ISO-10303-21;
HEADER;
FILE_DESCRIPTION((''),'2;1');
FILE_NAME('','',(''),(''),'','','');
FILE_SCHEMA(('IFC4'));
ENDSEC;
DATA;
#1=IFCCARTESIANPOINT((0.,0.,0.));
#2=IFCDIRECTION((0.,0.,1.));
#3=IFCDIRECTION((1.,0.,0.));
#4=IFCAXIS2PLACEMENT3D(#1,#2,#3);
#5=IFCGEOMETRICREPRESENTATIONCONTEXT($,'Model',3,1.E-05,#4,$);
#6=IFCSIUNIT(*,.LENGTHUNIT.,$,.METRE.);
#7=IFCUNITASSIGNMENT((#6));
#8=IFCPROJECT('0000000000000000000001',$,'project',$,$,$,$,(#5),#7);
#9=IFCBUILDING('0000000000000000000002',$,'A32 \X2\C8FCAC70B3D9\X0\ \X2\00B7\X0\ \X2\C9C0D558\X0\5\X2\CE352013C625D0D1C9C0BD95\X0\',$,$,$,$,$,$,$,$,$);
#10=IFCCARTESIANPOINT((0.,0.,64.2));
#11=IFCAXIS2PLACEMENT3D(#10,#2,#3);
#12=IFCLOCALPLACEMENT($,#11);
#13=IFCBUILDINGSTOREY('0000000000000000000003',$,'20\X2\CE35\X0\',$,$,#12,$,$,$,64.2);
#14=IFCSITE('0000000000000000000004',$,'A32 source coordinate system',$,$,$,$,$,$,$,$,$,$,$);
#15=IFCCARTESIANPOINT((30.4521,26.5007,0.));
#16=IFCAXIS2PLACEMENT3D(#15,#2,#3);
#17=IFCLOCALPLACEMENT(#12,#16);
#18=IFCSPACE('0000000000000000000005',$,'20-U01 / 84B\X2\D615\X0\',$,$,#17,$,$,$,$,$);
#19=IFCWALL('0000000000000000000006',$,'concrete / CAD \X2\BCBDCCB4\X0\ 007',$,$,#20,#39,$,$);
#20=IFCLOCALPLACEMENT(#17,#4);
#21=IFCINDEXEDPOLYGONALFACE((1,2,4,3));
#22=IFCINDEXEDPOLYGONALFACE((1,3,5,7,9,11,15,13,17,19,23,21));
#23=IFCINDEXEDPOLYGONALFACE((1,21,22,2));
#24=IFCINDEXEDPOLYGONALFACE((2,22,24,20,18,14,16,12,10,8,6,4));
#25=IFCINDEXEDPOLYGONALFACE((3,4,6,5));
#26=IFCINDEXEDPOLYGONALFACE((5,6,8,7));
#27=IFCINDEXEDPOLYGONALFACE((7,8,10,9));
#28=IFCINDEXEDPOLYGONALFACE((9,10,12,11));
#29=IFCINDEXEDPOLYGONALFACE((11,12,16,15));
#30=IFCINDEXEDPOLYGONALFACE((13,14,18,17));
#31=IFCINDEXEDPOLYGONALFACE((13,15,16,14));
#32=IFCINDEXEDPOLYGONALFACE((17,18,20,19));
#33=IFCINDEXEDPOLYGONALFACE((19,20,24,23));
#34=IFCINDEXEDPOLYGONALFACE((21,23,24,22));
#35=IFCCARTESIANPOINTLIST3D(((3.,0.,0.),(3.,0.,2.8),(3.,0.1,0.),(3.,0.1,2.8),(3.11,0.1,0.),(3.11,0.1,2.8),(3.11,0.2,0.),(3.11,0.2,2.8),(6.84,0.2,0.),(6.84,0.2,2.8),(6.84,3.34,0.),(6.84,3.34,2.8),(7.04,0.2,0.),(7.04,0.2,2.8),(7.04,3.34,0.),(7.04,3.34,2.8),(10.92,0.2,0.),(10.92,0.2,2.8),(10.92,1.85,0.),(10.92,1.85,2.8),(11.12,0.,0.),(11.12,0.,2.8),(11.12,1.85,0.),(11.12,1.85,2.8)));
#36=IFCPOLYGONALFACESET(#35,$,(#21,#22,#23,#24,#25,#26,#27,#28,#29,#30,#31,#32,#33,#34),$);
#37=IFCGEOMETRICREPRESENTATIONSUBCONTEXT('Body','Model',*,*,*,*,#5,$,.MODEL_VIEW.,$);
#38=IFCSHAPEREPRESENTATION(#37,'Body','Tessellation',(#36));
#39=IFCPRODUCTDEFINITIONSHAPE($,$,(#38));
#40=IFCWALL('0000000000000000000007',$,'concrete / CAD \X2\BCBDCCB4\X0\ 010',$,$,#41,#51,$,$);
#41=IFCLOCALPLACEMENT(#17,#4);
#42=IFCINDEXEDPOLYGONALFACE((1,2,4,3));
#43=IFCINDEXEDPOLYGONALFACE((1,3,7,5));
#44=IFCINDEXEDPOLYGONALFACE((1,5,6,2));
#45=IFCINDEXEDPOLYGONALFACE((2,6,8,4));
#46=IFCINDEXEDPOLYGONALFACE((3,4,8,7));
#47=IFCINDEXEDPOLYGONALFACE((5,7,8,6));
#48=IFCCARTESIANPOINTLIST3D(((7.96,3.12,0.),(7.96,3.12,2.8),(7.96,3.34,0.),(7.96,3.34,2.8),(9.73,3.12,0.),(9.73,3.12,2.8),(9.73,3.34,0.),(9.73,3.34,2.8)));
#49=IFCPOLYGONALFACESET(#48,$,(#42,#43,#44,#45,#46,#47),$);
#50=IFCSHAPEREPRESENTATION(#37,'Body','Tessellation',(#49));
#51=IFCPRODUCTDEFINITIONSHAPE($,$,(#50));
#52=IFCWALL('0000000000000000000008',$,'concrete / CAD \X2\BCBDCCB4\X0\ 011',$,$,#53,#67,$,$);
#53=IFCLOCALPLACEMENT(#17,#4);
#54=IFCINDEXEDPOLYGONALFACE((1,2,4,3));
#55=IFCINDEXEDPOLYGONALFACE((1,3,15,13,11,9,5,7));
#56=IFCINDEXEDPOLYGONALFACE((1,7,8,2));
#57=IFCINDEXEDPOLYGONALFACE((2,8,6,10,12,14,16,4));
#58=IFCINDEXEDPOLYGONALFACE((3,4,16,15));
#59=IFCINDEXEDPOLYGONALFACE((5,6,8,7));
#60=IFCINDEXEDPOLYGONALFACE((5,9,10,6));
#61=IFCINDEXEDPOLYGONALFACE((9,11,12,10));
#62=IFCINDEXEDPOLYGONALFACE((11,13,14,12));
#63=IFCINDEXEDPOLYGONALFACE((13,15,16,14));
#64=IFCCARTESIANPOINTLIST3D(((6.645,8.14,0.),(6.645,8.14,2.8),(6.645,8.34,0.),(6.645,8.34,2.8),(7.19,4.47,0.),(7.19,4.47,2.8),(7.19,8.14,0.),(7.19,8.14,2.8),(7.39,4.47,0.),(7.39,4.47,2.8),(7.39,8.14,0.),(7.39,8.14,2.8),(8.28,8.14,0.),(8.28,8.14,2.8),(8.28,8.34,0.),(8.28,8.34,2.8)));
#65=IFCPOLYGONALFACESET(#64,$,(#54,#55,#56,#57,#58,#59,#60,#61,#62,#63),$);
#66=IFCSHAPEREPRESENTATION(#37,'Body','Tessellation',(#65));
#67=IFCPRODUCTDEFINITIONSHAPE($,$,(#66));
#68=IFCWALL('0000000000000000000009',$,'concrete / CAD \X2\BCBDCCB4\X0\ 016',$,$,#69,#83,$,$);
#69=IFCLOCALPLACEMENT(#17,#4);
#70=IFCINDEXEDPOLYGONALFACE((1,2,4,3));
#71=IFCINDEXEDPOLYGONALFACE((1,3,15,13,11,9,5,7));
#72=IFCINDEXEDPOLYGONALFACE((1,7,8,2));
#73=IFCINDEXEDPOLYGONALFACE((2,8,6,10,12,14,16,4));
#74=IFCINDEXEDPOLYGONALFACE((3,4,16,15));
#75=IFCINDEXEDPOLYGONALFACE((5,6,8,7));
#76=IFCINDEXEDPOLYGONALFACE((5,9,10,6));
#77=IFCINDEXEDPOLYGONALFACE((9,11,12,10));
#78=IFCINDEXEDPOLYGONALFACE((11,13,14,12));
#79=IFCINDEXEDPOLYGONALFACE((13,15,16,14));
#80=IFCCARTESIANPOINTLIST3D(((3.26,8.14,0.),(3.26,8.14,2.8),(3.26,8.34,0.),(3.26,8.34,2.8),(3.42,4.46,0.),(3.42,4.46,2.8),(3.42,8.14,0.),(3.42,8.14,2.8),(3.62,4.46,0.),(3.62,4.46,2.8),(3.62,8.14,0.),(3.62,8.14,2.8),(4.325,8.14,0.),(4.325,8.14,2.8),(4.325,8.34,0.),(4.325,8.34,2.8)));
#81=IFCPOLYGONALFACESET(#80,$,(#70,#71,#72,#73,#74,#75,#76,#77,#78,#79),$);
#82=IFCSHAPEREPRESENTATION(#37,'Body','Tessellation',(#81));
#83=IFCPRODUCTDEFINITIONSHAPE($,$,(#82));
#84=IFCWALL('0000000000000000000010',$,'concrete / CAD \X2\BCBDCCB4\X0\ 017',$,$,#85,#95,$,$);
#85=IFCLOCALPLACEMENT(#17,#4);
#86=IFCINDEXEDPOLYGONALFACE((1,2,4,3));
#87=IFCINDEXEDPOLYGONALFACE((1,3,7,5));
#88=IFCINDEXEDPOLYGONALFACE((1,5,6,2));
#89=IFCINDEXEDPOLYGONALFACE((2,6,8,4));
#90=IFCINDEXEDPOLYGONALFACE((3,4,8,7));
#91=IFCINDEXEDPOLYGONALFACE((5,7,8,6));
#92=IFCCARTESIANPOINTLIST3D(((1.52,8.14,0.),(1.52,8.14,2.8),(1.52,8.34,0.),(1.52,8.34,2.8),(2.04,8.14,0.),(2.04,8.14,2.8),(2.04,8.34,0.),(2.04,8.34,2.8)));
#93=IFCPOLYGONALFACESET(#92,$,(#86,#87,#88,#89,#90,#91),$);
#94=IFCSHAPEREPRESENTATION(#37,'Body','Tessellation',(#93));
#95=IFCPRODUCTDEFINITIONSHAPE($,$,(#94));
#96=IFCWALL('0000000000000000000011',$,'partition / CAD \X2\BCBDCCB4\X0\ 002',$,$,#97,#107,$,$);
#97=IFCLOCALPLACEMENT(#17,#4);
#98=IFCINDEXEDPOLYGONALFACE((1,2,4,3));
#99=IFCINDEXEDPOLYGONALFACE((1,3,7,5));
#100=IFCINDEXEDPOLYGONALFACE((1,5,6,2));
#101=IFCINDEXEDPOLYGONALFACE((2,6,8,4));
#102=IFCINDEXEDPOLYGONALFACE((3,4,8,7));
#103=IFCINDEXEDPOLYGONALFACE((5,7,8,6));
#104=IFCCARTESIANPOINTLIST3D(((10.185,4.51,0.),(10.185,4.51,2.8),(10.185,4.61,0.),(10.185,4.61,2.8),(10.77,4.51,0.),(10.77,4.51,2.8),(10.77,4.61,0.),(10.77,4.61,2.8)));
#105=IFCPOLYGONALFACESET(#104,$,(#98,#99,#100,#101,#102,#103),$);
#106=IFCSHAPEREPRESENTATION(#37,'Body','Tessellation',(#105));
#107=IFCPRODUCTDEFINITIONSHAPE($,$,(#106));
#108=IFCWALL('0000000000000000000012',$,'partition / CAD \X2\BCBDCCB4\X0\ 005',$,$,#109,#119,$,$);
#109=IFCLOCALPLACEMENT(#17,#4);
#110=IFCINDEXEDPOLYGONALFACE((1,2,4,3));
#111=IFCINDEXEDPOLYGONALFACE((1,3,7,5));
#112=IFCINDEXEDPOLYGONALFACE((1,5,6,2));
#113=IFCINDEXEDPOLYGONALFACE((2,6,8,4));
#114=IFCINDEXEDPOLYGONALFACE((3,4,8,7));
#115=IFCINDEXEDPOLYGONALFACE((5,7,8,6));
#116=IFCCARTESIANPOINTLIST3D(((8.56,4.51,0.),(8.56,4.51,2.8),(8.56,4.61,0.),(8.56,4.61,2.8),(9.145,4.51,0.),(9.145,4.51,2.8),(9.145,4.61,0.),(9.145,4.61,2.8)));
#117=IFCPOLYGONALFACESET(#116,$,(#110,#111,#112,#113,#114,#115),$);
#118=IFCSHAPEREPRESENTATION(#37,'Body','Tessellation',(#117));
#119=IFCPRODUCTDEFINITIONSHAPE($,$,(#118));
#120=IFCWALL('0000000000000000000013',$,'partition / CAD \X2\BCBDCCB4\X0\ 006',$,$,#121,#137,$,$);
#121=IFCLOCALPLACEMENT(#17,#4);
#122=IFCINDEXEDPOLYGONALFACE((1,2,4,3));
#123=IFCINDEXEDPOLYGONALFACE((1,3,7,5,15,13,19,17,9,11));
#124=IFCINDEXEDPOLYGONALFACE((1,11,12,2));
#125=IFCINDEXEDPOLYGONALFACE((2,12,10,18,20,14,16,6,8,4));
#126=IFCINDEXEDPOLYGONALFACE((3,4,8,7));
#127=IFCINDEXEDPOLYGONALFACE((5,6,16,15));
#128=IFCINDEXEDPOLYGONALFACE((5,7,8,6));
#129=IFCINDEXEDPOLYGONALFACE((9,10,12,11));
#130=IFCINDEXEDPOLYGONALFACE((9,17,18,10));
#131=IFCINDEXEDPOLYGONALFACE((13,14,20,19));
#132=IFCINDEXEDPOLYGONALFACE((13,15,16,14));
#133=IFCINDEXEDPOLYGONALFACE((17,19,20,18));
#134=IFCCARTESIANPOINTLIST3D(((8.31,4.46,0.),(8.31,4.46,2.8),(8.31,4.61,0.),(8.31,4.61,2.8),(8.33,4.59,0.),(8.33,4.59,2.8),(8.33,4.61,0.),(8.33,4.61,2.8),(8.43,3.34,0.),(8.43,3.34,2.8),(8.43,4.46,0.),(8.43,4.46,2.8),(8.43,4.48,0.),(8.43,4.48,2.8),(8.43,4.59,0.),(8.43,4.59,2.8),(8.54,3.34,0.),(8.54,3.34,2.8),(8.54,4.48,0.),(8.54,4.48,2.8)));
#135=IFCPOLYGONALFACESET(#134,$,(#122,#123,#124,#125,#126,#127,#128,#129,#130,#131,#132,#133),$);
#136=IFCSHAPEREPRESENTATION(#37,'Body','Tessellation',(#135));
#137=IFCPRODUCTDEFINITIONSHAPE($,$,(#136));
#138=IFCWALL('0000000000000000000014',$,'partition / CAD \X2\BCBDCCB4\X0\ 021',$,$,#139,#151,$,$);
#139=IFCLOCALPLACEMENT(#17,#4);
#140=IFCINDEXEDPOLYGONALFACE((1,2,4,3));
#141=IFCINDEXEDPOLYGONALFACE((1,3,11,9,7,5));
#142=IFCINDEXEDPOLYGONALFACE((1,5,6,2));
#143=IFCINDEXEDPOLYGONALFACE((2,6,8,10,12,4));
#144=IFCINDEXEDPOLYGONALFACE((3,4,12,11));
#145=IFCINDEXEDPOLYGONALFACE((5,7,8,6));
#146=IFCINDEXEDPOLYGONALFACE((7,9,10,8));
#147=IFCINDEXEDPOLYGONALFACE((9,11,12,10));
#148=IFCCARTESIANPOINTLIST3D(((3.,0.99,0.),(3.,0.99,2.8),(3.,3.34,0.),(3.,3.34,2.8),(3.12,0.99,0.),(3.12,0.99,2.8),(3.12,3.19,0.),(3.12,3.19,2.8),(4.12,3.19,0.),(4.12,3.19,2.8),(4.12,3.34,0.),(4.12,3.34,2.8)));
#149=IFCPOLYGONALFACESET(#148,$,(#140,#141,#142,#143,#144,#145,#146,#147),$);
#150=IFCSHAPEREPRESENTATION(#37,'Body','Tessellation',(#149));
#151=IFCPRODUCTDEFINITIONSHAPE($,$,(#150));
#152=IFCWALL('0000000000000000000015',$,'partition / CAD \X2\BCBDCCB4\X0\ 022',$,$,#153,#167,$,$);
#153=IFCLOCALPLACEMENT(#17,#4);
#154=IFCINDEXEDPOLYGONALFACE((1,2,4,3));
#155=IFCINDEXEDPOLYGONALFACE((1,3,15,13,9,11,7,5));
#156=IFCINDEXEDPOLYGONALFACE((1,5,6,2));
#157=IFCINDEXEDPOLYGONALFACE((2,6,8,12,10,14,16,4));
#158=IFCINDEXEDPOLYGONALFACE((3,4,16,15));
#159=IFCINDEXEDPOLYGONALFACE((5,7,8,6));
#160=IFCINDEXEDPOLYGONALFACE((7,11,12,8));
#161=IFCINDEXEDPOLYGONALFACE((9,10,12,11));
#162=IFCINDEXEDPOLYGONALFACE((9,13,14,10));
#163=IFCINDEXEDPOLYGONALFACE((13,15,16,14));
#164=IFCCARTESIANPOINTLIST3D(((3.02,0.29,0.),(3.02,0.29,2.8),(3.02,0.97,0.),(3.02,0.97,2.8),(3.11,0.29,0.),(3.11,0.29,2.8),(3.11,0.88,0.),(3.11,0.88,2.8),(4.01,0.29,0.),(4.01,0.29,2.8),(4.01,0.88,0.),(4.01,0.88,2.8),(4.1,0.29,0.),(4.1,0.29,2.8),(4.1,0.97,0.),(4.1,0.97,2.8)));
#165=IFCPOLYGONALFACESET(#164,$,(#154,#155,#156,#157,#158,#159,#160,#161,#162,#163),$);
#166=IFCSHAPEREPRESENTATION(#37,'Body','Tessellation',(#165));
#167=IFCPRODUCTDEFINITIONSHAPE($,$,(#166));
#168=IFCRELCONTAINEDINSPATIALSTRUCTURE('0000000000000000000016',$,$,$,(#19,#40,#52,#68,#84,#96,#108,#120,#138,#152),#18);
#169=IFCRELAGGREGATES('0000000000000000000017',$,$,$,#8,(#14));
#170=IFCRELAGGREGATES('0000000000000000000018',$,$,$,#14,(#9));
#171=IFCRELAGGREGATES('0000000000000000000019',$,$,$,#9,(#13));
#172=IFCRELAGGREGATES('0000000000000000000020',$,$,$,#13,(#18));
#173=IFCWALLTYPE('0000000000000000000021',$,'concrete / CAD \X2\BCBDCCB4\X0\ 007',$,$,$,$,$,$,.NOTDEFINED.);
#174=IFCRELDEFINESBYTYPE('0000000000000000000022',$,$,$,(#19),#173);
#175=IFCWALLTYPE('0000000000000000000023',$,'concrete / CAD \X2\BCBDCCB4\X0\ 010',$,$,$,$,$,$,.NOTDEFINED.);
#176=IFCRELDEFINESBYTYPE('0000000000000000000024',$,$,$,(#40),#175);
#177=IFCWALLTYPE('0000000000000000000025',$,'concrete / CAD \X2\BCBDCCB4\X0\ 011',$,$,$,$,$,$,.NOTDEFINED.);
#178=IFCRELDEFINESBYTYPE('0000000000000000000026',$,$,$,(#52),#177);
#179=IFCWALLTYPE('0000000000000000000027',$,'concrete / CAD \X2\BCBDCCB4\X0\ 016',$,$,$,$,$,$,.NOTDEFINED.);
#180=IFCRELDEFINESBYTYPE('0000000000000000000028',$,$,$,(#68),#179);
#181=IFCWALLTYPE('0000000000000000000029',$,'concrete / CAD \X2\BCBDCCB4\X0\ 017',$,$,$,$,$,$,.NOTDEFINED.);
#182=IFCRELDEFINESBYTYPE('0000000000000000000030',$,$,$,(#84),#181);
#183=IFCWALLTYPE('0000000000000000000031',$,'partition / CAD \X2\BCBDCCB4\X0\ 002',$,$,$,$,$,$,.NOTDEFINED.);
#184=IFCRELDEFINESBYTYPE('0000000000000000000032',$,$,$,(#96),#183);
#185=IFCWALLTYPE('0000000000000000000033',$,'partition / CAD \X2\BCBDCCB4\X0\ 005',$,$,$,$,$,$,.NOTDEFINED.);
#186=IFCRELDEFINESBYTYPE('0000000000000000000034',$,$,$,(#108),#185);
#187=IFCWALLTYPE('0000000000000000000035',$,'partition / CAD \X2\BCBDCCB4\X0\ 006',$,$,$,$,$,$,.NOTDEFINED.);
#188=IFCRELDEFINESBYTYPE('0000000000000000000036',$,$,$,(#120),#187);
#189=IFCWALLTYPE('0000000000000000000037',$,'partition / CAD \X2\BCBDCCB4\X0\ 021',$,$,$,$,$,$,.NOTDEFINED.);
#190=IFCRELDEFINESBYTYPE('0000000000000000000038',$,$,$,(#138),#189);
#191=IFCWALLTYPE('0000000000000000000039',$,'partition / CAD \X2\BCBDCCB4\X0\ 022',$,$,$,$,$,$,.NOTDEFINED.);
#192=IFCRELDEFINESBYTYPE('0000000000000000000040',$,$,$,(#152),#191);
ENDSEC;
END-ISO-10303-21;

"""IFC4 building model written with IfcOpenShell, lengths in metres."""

from ifc_helpers import new_model, si_unit, frame, origin, origin_with_axes, place, context, subcontext, project, spatial, polyline, outline, extrude, source, transform, mapped, type_object, type_shapes, element, save


model = new_model("IFC4")

# Units and contexts
model_context = context("Model", 3, precision=1e-05, world=origin_with_axes())
body_context = subcontext(model_context, "Body", "Model", "MODEL_VIEW")
ifc_project = project(units=[si_unit("LENGTHUNIT", "METRE")], contexts=[model_context])

# Site, building, storey, space
site = spatial("IfcSite", under=ifc_project, Name="A32 source coordinate system")
building = spatial("IfcBuilding", under=site, Name="A32 주거동 · 지하5층–옥탑지붕")
storey_placement = place(None, frame((0.0, 0.0, 64.2), z_axis=(0.0, 0.0, 1.0), x_axis=(1.0, 0.0, 0.0)))
storey = spatial("IfcBuildingStorey", under=building, at=storey_placement, Name="20층", Elevation=64.2)
space_1_placement = place(storey_placement, frame((30.4521, 26.5007, 0.0), z_axis=(0.0, 0.0, 1.0), x_axis=(1.0, 0.0, 0.0)))
space_1 = spatial("IfcSpace", under=storey, at=space_1_placement, Name="20-U01 / 84B형")

# Walls
wall_type_1 = type_object("IfcWallType", Name="concrete / CAD 벽체 007", PredefinedType="NOTDEFINED")
shared_shape_1 = source(origin(), body_context, "Body", "SweptSolid", [
    extrude(outline(polyline([(3.0, 0.0), (3.0, 0.1), (3.11, 0.1), (3.11, 0.2), (6.84, 0.2), (6.84, 3.34), (7.04, 3.34), (7.04, 0.2), (10.92, 0.2), (10.92, 1.85), (11.12, 1.85), (11.12, 0.0), (3.0, 0.0)])), origin(), (0.0, 0.0, 1.0), 2.8),
])
type_shapes(wall_type_1, [shared_shape_1])
wall_1_placement = place(space_1_placement, origin_with_axes())
element("IfcWall", 1, at=wall_1_placement, inside=space_1, type_object=wall_type_1, Name="concrete / CAD 벽체 007", context=body_context, shape_type="MappedRepresentation", body=[
    mapped(shared_shape_1, transform((0.0, 0.0, 0.0), scale=1.0)),
])
wall_type_2 = type_object("IfcWallType", Name="concrete / CAD 벽체 010", PredefinedType="NOTDEFINED")
shared_shape_2 = source(origin(), body_context, "Body", "SweptSolid", [
    extrude(outline(polyline([(7.96, 3.12), (7.96, 3.34), (9.73, 3.34), (9.73, 3.12), (7.96, 3.12)])), origin(), (0.0, 0.0, 1.0), 2.8),
])
type_shapes(wall_type_2, [shared_shape_2])
wall_2_placement = place(space_1_placement, origin_with_axes())
element("IfcWall", 2, at=wall_2_placement, inside=space_1, type_object=wall_type_2, Name="concrete / CAD 벽체 010", context=body_context, shape_type="MappedRepresentation", body=[
    mapped(shared_shape_2, transform((0.0, 0.0, 0.0), scale=1.0)),
])
wall_type_3 = type_object("IfcWallType", Name="concrete / CAD 벽체 011", PredefinedType="NOTDEFINED")
shared_shape_3 = source(origin(), body_context, "Body", "SweptSolid", [
    extrude(outline(polyline([(7.19, 8.14), (6.645, 8.14), (6.645, 8.34), (8.28, 8.34), (8.28, 8.14), (7.39, 8.14), (7.39, 4.47), (7.19, 4.47), (7.19, 8.14)])), origin(), (0.0, 0.0, 1.0), 2.8),
])
type_shapes(wall_type_3, [shared_shape_3])
wall_3_placement = place(space_1_placement, origin_with_axes())
element("IfcWall", 3, at=wall_3_placement, inside=space_1, type_object=wall_type_3, Name="concrete / CAD 벽체 011", context=body_context, shape_type="MappedRepresentation", body=[
    mapped(shared_shape_3, transform((0.0, 0.0, 0.0), scale=1.0)),
])
wall_type_4 = type_object("IfcWallType", Name="concrete / CAD 벽체 016", PredefinedType="NOTDEFINED")
shared_shape_4 = source(origin(), body_context, "Body", "SweptSolid", [
    extrude(outline(polyline([(3.26, 8.14), (3.26, 8.34), (4.325, 8.34), (4.325, 8.14), (3.62, 8.14), (3.62, 4.46), (3.42, 4.46), (3.42, 8.14), (3.26, 8.14)])), origin(), (0.0, 0.0, 1.0), 2.8),
])
type_shapes(wall_type_4, [shared_shape_4])
wall_4_placement = place(space_1_placement, origin_with_axes())
element("IfcWall", 4, at=wall_4_placement, inside=space_1, type_object=wall_type_4, Name="concrete / CAD 벽체 016", context=body_context, shape_type="MappedRepresentation", body=[
    mapped(shared_shape_4, transform((0.0, 0.0, 0.0), scale=1.0)),
])
wall_type_5 = type_object("IfcWallType", Name="concrete / CAD 벽체 017", PredefinedType="NOTDEFINED")
shared_shape_5 = source(origin(), body_context, "Body", "SweptSolid", [
    extrude(outline(polyline([(1.52, 8.34), (2.04, 8.34), (2.04, 8.14), (1.52, 8.14), (1.52, 8.34)])), origin(), (0.0, 0.0, 1.0), 2.8),
])
type_shapes(wall_type_5, [shared_shape_5])
wall_5_placement = place(space_1_placement, origin_with_axes())
element("IfcWall", 5, at=wall_5_placement, inside=space_1, type_object=wall_type_5, Name="concrete / CAD 벽체 017", context=body_context, shape_type="MappedRepresentation", body=[
    mapped(shared_shape_5, transform((0.0, 0.0, 0.0), scale=1.0)),
])
wall_type_6 = type_object("IfcWallType", Name="partition / CAD 벽체 002", PredefinedType="NOTDEFINED")
shared_shape_6 = source(origin(), body_context, "Body", "SweptSolid", [
    extrude(outline(polyline([(10.185, 4.51), (10.185, 4.61), (10.77, 4.61), (10.77, 4.51), (10.185, 4.51)])), origin(), (0.0, 0.0, 1.0), 2.8),
])
type_shapes(wall_type_6, [shared_shape_6])
wall_6_placement = place(space_1_placement, origin_with_axes())
element("IfcWall", 6, at=wall_6_placement, inside=space_1, type_object=wall_type_6, Name="partition / CAD 벽체 002", context=body_context, shape_type="MappedRepresentation", body=[
    mapped(shared_shape_6, transform((0.0, 0.0, 0.0), scale=1.0)),
])
wall_type_7 = type_object("IfcWallType", Name="partition / CAD 벽체 005", PredefinedType="NOTDEFINED")
shared_shape_7 = source(origin(), body_context, "Body", "SweptSolid", [
    extrude(outline(polyline([(8.56, 4.51), (8.56, 4.61), (9.145, 4.61), (9.145, 4.51), (8.56, 4.51)])), origin(), (0.0, 0.0, 1.0), 2.8),
])
type_shapes(wall_type_7, [shared_shape_7])
wall_7_placement = place(space_1_placement, origin_with_axes())
element("IfcWall", 7, at=wall_7_placement, inside=space_1, type_object=wall_type_7, Name="partition / CAD 벽체 005", context=body_context, shape_type="MappedRepresentation", body=[
    mapped(shared_shape_7, transform((0.0, 0.0, 0.0), scale=1.0)),
])
wall_type_8 = type_object("IfcWallType", Name="partition / CAD 벽체 006", PredefinedType="NOTDEFINED")
shared_shape_8 = source(origin(), body_context, "Body", "SweptSolid", [
    extrude(outline(polyline([(8.43, 4.46), (8.31, 4.46), (8.31, 4.61), (8.33, 4.61), (8.33, 4.59), (8.43, 4.59), (8.43, 4.48), (8.54, 4.48), (8.54, 3.34), (8.43, 3.34), (8.43, 4.46)])), origin(), (0.0, 0.0, 1.0), 2.8),
])
type_shapes(wall_type_8, [shared_shape_8])
wall_8_placement = place(space_1_placement, origin_with_axes())
element("IfcWall", 8, at=wall_8_placement, inside=space_1, type_object=wall_type_8, Name="partition / CAD 벽체 006", context=body_context, shape_type="MappedRepresentation", body=[
    mapped(shared_shape_8, transform((0.0, 0.0, 0.0), scale=1.0)),
])
wall_type_9 = type_object("IfcWallType", Name="partition / CAD 벽체 021", PredefinedType="NOTDEFINED")
shared_shape_9 = source(origin(), body_context, "Body", "SweptSolid", [
    extrude(outline(polyline([(4.12, 3.34), (4.12, 3.19), (3.12, 3.19), (3.12, 0.99), (3.0, 0.99), (3.0, 3.34), (4.12, 3.34)])), origin(), (0.0, 0.0, 1.0), 2.8),
])
type_shapes(wall_type_9, [shared_shape_9])
wall_9_placement = place(space_1_placement, origin_with_axes())
element("IfcWall", 9, at=wall_9_placement, inside=space_1, type_object=wall_type_9, Name="partition / CAD 벽체 021", context=body_context, shape_type="MappedRepresentation", body=[
    mapped(shared_shape_9, transform((0.0, 0.0, 0.0), scale=1.0)),
])
wall_type_10 = type_object("IfcWallType", Name="partition / CAD 벽체 022", PredefinedType="NOTDEFINED")
shared_shape_10 = source(origin(), body_context, "Body", "SweptSolid", [
    extrude(outline(polyline([(4.1, 0.97), (4.1, 0.29), (4.01, 0.29), (4.01, 0.88), (3.11, 0.88), (3.11, 0.29), (3.02, 0.29), (3.02, 0.97), (4.1, 0.97)])), origin(), (0.0, 0.0, 1.0), 2.8),
])
type_shapes(wall_type_10, [shared_shape_10])
wall_10_placement = place(space_1_placement, origin_with_axes())
element("IfcWall", 10, at=wall_10_placement, inside=space_1, type_object=wall_type_10, Name="partition / CAD 벽체 022", context=body_context, shape_type="MappedRepresentation", body=[
    mapped(shared_shape_10, transform((0.0, 0.0, 0.0), scale=1.0)),
])

save(model, "model.ifc")
